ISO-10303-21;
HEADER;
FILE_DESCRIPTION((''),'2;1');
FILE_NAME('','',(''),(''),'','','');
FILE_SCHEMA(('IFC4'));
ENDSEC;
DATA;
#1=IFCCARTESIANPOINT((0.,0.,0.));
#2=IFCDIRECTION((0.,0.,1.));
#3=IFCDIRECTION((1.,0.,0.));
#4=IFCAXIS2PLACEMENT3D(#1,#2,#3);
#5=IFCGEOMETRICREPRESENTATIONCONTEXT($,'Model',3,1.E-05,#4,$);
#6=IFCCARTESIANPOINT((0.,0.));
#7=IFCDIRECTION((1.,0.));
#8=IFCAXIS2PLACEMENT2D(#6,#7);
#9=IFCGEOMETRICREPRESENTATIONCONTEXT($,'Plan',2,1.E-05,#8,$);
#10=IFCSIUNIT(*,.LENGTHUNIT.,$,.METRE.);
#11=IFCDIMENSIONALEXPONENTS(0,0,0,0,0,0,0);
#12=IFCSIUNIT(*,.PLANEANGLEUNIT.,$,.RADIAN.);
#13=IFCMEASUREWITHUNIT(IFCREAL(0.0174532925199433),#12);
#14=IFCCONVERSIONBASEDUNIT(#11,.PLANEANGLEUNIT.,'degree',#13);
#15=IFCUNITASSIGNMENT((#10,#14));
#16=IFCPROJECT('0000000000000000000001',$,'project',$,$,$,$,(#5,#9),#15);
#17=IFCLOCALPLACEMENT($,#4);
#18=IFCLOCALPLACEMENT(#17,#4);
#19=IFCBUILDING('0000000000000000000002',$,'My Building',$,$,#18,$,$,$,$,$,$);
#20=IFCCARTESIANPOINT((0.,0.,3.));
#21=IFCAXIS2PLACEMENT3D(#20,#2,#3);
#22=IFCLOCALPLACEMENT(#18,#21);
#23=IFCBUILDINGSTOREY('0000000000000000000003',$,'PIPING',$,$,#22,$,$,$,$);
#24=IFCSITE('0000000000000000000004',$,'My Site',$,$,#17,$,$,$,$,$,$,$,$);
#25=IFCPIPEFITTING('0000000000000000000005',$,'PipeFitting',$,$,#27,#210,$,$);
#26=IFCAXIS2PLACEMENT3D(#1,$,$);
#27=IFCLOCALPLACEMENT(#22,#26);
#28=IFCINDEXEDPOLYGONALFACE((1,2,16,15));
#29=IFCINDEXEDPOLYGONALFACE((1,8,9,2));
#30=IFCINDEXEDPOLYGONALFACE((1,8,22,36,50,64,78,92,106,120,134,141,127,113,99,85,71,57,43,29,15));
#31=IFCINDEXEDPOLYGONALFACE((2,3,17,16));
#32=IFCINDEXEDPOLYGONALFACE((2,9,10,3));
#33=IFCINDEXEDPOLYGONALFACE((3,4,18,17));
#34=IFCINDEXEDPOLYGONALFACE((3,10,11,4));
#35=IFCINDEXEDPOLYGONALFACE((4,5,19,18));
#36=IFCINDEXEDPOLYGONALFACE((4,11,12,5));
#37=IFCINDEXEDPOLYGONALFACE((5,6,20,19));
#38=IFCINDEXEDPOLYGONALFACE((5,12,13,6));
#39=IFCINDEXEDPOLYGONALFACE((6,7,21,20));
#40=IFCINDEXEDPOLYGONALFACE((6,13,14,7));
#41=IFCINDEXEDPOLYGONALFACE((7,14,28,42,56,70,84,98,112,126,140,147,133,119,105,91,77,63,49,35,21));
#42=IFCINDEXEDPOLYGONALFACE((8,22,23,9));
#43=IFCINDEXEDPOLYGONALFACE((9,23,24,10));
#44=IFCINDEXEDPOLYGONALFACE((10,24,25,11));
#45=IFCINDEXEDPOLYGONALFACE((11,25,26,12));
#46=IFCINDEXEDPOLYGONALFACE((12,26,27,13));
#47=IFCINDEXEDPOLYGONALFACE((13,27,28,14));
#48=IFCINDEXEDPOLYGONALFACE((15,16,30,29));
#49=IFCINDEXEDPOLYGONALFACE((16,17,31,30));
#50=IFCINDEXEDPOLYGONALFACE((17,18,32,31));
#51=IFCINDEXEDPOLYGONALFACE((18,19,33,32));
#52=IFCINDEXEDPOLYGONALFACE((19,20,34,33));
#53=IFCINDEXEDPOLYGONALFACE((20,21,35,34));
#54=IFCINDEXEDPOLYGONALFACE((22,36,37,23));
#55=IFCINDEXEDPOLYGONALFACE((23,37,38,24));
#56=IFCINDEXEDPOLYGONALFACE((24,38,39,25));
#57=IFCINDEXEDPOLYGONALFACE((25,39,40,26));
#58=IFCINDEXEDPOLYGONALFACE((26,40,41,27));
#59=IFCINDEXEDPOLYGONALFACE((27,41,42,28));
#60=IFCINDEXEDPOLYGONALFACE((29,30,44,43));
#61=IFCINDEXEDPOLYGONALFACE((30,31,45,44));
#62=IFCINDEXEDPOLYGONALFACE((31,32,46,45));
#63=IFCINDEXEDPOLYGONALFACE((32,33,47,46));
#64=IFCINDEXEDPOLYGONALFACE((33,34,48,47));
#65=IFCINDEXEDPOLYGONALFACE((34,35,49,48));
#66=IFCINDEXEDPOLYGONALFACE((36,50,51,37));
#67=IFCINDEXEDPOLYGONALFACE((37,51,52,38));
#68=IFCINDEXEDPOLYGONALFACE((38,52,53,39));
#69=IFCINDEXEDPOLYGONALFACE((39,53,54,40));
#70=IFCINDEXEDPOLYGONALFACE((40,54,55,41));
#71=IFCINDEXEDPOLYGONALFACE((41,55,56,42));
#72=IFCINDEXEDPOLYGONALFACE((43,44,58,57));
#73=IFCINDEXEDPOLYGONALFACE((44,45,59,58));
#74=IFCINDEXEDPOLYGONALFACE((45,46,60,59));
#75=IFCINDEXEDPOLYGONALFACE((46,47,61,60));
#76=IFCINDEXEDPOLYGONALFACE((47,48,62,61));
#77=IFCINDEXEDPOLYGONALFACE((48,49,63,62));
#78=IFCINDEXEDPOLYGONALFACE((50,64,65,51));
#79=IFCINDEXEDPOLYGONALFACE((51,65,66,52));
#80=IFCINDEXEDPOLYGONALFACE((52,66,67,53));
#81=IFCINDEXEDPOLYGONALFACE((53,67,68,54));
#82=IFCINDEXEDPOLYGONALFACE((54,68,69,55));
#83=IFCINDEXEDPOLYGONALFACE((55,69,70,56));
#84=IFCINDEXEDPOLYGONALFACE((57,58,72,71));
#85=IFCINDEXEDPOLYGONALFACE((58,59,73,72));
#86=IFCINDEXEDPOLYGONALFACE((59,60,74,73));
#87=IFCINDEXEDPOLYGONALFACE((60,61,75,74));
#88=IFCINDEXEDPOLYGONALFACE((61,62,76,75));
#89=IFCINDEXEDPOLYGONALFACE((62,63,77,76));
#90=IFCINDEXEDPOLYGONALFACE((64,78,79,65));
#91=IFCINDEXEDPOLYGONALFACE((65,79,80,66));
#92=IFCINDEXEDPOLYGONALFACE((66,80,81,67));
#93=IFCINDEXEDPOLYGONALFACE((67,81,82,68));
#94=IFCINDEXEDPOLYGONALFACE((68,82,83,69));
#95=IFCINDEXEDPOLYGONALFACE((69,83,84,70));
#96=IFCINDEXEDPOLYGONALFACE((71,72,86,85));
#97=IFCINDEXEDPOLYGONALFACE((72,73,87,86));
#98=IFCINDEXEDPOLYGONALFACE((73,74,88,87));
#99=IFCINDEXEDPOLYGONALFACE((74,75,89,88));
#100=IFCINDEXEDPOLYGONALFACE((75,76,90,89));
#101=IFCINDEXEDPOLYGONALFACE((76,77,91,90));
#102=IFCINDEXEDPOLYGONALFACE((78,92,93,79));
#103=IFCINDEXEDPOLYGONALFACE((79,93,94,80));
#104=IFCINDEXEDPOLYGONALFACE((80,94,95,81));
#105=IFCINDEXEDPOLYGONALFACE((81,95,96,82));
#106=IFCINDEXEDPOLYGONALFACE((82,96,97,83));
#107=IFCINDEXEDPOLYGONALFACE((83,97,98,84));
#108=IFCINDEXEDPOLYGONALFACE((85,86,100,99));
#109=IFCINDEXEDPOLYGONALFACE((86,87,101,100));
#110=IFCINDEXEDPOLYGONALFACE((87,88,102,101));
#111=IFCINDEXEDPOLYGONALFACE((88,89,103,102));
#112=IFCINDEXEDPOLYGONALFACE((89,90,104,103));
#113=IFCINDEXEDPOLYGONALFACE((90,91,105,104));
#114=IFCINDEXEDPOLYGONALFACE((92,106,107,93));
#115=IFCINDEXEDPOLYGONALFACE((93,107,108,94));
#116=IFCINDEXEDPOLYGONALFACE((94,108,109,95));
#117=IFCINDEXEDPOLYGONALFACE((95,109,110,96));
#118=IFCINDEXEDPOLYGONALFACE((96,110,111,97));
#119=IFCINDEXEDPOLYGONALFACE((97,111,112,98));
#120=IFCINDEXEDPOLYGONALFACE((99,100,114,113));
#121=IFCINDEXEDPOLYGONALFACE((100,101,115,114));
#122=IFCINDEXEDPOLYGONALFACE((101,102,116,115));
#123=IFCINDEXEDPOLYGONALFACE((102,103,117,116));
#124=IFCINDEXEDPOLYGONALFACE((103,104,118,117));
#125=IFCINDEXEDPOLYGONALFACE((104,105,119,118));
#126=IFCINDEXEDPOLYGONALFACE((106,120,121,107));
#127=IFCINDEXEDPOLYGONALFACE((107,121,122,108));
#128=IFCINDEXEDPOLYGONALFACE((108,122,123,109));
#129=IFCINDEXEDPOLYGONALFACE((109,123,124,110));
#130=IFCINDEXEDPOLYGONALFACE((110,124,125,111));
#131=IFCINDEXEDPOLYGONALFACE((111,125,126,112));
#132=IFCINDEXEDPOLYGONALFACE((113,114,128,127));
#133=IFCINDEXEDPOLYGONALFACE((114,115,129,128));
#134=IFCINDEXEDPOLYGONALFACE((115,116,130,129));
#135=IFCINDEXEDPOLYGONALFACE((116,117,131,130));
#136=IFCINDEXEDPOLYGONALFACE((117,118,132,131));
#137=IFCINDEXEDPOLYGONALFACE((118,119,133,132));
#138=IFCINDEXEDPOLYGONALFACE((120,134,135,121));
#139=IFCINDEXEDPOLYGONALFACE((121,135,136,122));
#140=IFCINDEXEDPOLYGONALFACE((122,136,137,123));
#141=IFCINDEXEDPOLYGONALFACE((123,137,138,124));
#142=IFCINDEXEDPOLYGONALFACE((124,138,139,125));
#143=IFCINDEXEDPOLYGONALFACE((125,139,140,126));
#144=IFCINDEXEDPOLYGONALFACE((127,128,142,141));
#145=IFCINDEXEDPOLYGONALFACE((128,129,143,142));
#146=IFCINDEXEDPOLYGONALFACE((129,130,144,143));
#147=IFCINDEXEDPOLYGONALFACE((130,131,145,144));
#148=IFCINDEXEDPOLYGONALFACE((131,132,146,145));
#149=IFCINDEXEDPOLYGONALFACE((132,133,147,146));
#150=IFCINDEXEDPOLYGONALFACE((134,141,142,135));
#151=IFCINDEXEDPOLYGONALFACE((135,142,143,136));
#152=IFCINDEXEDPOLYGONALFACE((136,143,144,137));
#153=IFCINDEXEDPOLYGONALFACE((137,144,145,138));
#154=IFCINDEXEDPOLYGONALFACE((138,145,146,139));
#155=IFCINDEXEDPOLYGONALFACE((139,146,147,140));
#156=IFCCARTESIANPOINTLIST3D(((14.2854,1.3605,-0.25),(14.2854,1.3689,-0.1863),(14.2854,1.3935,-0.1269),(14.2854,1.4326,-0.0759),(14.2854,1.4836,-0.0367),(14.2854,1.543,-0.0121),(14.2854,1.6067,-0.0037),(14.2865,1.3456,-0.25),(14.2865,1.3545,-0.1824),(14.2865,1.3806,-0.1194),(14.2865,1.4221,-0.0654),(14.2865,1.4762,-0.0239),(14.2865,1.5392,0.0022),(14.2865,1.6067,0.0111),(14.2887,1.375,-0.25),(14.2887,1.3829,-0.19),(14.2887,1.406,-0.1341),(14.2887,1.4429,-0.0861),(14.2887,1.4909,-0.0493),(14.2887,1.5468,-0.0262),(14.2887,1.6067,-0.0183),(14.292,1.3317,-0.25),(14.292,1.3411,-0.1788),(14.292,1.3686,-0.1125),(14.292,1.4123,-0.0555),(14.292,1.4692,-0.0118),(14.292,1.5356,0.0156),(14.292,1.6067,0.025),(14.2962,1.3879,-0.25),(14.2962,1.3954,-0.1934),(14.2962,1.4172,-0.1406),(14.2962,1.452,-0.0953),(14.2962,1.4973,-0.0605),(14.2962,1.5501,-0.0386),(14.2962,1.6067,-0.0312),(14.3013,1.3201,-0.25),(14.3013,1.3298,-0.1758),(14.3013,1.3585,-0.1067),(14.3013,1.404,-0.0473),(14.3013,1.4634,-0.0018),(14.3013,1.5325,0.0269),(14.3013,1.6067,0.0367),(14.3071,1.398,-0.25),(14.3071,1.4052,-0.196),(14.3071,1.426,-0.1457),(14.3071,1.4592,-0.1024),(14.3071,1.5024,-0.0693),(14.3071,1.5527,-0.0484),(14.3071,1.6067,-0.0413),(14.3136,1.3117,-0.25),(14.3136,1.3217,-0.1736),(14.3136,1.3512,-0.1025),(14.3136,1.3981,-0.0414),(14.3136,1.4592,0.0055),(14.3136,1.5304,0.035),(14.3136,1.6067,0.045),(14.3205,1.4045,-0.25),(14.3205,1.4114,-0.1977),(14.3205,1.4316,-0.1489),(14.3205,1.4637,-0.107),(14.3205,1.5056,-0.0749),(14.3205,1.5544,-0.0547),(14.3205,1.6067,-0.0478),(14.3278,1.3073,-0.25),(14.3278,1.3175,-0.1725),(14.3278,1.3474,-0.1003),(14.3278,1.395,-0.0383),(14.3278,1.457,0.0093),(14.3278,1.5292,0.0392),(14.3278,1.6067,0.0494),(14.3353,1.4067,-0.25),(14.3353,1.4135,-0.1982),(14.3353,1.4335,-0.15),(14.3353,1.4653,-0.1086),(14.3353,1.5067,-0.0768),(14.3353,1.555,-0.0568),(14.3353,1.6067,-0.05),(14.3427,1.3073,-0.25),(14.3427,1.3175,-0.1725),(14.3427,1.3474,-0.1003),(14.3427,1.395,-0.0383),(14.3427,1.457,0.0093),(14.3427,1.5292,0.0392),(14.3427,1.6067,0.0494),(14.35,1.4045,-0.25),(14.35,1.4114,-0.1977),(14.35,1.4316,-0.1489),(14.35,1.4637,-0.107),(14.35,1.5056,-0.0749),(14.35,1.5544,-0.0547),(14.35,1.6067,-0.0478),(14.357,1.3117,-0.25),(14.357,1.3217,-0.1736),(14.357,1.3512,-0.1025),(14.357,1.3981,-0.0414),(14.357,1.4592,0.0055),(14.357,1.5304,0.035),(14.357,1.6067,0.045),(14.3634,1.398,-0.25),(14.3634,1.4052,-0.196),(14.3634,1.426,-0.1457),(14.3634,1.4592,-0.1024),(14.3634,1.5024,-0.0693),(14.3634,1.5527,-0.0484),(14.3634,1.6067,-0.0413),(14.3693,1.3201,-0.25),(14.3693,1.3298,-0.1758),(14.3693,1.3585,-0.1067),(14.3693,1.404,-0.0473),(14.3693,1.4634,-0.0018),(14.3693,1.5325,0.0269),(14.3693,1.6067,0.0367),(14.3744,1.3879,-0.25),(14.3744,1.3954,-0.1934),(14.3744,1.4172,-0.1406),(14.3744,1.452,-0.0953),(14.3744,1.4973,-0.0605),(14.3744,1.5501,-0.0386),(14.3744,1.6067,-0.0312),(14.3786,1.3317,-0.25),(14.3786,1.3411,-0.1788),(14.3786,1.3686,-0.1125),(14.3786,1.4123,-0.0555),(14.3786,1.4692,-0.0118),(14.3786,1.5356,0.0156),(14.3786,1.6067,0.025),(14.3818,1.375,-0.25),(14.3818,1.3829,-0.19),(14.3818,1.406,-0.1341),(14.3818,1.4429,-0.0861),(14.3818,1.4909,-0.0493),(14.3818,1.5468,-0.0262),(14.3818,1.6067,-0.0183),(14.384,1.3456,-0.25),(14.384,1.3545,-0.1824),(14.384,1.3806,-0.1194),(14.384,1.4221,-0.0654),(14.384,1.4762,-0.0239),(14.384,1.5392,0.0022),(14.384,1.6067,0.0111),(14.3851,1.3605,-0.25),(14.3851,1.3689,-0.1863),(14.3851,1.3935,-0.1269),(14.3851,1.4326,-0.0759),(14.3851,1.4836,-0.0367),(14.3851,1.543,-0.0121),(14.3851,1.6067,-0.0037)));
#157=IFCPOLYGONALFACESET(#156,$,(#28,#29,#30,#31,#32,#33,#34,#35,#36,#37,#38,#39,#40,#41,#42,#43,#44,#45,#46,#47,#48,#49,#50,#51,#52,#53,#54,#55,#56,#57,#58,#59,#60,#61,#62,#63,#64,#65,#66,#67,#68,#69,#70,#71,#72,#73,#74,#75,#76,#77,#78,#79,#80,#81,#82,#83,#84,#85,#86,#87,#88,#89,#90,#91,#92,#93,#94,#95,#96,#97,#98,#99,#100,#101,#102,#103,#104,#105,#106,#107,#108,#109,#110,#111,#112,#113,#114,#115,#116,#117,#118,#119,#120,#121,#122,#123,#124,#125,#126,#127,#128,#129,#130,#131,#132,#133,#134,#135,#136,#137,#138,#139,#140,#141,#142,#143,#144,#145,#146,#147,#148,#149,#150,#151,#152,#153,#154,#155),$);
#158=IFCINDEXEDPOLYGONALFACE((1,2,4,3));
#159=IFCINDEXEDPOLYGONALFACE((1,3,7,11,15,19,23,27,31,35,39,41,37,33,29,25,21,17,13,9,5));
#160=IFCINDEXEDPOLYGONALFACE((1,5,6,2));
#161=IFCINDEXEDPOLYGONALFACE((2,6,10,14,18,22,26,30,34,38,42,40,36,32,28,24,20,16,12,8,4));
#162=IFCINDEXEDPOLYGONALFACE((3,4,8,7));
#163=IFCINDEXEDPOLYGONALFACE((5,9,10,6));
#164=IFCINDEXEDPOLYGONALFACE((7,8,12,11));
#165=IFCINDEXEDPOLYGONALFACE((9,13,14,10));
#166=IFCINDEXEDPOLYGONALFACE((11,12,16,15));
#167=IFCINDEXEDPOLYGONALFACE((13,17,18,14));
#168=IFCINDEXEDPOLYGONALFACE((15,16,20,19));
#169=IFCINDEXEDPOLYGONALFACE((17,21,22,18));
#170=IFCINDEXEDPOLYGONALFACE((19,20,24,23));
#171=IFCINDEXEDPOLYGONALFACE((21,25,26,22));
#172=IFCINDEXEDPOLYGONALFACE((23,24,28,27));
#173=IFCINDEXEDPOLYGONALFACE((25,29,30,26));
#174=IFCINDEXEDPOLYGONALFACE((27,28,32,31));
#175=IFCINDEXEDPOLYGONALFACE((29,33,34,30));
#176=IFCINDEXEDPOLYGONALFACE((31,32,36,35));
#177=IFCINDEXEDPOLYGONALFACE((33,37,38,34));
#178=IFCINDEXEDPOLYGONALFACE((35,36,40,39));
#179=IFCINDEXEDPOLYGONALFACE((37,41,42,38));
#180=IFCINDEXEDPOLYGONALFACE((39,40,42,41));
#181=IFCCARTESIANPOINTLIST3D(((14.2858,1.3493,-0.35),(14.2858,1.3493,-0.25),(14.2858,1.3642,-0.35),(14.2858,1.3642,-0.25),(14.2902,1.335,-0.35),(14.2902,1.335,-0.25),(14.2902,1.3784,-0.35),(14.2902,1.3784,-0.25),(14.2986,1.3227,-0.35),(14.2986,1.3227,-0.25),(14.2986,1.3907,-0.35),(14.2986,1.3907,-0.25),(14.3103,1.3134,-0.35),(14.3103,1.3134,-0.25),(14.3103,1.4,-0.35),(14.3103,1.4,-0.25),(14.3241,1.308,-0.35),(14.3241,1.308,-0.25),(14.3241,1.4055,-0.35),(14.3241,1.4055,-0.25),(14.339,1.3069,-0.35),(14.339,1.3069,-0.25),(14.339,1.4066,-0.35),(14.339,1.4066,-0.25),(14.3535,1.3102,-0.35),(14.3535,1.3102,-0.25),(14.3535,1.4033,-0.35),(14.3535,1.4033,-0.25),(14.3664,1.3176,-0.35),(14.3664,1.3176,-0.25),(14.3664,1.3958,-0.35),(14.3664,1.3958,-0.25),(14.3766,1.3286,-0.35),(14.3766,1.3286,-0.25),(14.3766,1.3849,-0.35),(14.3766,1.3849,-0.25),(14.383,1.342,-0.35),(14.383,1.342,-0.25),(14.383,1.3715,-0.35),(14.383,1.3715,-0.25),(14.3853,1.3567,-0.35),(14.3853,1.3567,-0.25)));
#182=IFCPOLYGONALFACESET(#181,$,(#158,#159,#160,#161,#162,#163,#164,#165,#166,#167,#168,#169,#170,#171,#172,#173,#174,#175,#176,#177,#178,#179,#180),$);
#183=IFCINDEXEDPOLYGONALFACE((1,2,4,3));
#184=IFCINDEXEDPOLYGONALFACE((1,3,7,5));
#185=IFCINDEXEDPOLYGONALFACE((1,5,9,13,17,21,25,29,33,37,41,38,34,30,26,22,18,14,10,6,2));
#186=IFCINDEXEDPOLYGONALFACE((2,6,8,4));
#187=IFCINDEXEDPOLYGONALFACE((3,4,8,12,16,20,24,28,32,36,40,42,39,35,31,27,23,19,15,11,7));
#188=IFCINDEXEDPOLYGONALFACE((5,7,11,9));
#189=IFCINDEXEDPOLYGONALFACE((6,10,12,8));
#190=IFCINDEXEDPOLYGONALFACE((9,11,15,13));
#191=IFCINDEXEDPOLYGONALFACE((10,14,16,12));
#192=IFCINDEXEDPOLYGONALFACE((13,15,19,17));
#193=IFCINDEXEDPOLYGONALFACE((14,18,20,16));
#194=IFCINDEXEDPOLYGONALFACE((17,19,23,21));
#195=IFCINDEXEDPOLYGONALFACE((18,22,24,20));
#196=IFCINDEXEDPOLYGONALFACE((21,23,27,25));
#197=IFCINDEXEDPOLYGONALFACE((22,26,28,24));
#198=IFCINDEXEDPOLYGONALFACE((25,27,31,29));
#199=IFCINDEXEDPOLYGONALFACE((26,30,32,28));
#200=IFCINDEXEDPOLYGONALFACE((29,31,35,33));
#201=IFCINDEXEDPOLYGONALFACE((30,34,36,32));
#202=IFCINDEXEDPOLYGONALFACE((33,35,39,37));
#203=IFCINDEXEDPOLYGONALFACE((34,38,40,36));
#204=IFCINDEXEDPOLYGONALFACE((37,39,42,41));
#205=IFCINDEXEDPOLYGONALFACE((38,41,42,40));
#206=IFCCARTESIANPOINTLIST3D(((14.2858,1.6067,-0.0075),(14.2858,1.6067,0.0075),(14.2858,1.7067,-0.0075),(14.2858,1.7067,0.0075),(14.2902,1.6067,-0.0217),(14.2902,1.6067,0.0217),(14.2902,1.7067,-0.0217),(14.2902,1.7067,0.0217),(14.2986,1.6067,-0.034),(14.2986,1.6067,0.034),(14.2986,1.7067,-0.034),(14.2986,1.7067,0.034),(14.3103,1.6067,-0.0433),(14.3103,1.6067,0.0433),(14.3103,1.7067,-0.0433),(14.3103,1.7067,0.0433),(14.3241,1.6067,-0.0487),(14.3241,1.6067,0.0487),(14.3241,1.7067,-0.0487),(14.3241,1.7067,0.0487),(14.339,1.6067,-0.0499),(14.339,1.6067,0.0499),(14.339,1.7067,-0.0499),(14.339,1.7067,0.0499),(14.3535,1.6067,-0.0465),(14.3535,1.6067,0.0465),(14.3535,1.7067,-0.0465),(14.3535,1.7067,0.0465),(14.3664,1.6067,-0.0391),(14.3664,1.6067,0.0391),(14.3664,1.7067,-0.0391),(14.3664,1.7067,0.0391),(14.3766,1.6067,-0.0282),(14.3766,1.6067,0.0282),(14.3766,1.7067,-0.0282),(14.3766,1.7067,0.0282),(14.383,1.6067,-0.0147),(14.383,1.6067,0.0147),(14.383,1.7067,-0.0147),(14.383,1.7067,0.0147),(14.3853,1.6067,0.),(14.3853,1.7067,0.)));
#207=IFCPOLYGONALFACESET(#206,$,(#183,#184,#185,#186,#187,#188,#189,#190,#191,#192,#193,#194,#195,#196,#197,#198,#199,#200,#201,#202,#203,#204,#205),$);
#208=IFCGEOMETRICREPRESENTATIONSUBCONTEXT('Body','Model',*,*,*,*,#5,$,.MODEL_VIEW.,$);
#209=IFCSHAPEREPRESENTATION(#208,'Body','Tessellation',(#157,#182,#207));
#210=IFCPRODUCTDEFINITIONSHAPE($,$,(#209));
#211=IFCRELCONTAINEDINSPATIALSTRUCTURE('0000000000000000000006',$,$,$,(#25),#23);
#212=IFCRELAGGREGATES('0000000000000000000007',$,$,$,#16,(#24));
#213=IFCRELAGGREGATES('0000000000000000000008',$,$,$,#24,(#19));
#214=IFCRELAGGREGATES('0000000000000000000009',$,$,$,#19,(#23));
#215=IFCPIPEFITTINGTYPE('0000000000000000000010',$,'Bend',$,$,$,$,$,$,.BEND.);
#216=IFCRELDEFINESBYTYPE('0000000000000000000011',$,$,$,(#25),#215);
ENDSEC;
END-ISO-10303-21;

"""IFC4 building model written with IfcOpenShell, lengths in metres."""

from ifc_helpers import new_model, entity, si_unit, converted_unit, frame, origin_with_axes, origin_2d_with_axis, place, context, subcontext, project, spatial, circle, extrude, source, transform, mapped, type_object, type_shapes, element, save


model = new_model("IFC4")

# Units and contexts
model_context = context("Model", 3, precision=1e-05, world=origin_with_axes())
plan_context = context("Plan", 2, precision=1e-05, world=origin_2d_with_axis())
body_context = subcontext(model_context, "Body", "Model", "MODEL_VIEW")
ifc_project = project(units=[si_unit("LENGTHUNIT", "METRE"), converted_unit("PLANEANGLEUNIT", "degree", entity("IfcReal", 0.0174532925199433), si_unit("PLANEANGLEUNIT", "RADIAN"), dimensions=[0, 0, 0, 0, 0, 0, 0])], contexts=[model_context, plan_context])

# Site, building, storey
site_placement = place(None, origin_with_axes())
site = spatial("IfcSite", under=ifc_project, at=site_placement, Name="My Site")
building_placement = place(site_placement, origin_with_axes())
building = spatial("IfcBuilding", under=site, at=building_placement, Name="My Building")
storey_placement = place(building_placement, frame((0.0, 0.0, 3.0), z_axis=(0.0, 0.0, 1.0), x_axis=(1.0, 0.0, 0.0)))
storey = spatial("IfcBuildingStorey", under=building, at=storey_placement, Name="PIPING")

# Pipe fitting
pipe_fitting_type_1 = type_object("IfcPipeFittingType", Name="Bend", PredefinedType="BEND")
shared_shape = source(origin_with_axes(), body_context, "Body", "SolidModel", [
    entity("IfcSweptDiskSolid", entity("IfcIndexedPolyCurve", entity("IfcCartesianPointList3D", [[0.0, 0.0, -0.1], [0.0, -0.0732, -0.2768], [0.0, -0.25, -0.35]]), [entity("IfcArcIndex", [1, 2, 3])]), 0.05),
    extrude(circle(Radius=0.05), origin_with_axes(), (0.0, 0.0, -1.0), 0.1),
    extrude(circle(Radius=0.05), frame((0.0, -0.25, -0.35), z_axis=(0.0, -1.0, 0.0), x_axis=(1.0, 0.0, 0.0)), (0.0, 0.0, 1.0), 0.1),
])
type_shapes(pipe_fitting_type_1, [shared_shape])
for number, where, z_axis, x_axis, name in (
    (1, (14.3353, 1.3567, -0.35), (0.0, 0.0, -1.0), (1.0, 0.0, 0.0), "PipeFitting"),
):
    element("IfcPipeFitting", number, at=place(storey_placement, frame(where, z_axis=z_axis, x_axis=x_axis)), inside=storey, type_object=pipe_fitting_type_1, Name=name, context=body_context, shape_type="MappedRepresentation", body=[
        mapped(shared_shape, transform((0.0, 0.0, 0.0), x_axis=(1.0, 0.0, 0.0), y_axis=(0.0, 1.0, 0.0), z_axis=(0.0, 0.0, 1.0), scale=1.0)),
    ])

save(model, "model.ifc")
